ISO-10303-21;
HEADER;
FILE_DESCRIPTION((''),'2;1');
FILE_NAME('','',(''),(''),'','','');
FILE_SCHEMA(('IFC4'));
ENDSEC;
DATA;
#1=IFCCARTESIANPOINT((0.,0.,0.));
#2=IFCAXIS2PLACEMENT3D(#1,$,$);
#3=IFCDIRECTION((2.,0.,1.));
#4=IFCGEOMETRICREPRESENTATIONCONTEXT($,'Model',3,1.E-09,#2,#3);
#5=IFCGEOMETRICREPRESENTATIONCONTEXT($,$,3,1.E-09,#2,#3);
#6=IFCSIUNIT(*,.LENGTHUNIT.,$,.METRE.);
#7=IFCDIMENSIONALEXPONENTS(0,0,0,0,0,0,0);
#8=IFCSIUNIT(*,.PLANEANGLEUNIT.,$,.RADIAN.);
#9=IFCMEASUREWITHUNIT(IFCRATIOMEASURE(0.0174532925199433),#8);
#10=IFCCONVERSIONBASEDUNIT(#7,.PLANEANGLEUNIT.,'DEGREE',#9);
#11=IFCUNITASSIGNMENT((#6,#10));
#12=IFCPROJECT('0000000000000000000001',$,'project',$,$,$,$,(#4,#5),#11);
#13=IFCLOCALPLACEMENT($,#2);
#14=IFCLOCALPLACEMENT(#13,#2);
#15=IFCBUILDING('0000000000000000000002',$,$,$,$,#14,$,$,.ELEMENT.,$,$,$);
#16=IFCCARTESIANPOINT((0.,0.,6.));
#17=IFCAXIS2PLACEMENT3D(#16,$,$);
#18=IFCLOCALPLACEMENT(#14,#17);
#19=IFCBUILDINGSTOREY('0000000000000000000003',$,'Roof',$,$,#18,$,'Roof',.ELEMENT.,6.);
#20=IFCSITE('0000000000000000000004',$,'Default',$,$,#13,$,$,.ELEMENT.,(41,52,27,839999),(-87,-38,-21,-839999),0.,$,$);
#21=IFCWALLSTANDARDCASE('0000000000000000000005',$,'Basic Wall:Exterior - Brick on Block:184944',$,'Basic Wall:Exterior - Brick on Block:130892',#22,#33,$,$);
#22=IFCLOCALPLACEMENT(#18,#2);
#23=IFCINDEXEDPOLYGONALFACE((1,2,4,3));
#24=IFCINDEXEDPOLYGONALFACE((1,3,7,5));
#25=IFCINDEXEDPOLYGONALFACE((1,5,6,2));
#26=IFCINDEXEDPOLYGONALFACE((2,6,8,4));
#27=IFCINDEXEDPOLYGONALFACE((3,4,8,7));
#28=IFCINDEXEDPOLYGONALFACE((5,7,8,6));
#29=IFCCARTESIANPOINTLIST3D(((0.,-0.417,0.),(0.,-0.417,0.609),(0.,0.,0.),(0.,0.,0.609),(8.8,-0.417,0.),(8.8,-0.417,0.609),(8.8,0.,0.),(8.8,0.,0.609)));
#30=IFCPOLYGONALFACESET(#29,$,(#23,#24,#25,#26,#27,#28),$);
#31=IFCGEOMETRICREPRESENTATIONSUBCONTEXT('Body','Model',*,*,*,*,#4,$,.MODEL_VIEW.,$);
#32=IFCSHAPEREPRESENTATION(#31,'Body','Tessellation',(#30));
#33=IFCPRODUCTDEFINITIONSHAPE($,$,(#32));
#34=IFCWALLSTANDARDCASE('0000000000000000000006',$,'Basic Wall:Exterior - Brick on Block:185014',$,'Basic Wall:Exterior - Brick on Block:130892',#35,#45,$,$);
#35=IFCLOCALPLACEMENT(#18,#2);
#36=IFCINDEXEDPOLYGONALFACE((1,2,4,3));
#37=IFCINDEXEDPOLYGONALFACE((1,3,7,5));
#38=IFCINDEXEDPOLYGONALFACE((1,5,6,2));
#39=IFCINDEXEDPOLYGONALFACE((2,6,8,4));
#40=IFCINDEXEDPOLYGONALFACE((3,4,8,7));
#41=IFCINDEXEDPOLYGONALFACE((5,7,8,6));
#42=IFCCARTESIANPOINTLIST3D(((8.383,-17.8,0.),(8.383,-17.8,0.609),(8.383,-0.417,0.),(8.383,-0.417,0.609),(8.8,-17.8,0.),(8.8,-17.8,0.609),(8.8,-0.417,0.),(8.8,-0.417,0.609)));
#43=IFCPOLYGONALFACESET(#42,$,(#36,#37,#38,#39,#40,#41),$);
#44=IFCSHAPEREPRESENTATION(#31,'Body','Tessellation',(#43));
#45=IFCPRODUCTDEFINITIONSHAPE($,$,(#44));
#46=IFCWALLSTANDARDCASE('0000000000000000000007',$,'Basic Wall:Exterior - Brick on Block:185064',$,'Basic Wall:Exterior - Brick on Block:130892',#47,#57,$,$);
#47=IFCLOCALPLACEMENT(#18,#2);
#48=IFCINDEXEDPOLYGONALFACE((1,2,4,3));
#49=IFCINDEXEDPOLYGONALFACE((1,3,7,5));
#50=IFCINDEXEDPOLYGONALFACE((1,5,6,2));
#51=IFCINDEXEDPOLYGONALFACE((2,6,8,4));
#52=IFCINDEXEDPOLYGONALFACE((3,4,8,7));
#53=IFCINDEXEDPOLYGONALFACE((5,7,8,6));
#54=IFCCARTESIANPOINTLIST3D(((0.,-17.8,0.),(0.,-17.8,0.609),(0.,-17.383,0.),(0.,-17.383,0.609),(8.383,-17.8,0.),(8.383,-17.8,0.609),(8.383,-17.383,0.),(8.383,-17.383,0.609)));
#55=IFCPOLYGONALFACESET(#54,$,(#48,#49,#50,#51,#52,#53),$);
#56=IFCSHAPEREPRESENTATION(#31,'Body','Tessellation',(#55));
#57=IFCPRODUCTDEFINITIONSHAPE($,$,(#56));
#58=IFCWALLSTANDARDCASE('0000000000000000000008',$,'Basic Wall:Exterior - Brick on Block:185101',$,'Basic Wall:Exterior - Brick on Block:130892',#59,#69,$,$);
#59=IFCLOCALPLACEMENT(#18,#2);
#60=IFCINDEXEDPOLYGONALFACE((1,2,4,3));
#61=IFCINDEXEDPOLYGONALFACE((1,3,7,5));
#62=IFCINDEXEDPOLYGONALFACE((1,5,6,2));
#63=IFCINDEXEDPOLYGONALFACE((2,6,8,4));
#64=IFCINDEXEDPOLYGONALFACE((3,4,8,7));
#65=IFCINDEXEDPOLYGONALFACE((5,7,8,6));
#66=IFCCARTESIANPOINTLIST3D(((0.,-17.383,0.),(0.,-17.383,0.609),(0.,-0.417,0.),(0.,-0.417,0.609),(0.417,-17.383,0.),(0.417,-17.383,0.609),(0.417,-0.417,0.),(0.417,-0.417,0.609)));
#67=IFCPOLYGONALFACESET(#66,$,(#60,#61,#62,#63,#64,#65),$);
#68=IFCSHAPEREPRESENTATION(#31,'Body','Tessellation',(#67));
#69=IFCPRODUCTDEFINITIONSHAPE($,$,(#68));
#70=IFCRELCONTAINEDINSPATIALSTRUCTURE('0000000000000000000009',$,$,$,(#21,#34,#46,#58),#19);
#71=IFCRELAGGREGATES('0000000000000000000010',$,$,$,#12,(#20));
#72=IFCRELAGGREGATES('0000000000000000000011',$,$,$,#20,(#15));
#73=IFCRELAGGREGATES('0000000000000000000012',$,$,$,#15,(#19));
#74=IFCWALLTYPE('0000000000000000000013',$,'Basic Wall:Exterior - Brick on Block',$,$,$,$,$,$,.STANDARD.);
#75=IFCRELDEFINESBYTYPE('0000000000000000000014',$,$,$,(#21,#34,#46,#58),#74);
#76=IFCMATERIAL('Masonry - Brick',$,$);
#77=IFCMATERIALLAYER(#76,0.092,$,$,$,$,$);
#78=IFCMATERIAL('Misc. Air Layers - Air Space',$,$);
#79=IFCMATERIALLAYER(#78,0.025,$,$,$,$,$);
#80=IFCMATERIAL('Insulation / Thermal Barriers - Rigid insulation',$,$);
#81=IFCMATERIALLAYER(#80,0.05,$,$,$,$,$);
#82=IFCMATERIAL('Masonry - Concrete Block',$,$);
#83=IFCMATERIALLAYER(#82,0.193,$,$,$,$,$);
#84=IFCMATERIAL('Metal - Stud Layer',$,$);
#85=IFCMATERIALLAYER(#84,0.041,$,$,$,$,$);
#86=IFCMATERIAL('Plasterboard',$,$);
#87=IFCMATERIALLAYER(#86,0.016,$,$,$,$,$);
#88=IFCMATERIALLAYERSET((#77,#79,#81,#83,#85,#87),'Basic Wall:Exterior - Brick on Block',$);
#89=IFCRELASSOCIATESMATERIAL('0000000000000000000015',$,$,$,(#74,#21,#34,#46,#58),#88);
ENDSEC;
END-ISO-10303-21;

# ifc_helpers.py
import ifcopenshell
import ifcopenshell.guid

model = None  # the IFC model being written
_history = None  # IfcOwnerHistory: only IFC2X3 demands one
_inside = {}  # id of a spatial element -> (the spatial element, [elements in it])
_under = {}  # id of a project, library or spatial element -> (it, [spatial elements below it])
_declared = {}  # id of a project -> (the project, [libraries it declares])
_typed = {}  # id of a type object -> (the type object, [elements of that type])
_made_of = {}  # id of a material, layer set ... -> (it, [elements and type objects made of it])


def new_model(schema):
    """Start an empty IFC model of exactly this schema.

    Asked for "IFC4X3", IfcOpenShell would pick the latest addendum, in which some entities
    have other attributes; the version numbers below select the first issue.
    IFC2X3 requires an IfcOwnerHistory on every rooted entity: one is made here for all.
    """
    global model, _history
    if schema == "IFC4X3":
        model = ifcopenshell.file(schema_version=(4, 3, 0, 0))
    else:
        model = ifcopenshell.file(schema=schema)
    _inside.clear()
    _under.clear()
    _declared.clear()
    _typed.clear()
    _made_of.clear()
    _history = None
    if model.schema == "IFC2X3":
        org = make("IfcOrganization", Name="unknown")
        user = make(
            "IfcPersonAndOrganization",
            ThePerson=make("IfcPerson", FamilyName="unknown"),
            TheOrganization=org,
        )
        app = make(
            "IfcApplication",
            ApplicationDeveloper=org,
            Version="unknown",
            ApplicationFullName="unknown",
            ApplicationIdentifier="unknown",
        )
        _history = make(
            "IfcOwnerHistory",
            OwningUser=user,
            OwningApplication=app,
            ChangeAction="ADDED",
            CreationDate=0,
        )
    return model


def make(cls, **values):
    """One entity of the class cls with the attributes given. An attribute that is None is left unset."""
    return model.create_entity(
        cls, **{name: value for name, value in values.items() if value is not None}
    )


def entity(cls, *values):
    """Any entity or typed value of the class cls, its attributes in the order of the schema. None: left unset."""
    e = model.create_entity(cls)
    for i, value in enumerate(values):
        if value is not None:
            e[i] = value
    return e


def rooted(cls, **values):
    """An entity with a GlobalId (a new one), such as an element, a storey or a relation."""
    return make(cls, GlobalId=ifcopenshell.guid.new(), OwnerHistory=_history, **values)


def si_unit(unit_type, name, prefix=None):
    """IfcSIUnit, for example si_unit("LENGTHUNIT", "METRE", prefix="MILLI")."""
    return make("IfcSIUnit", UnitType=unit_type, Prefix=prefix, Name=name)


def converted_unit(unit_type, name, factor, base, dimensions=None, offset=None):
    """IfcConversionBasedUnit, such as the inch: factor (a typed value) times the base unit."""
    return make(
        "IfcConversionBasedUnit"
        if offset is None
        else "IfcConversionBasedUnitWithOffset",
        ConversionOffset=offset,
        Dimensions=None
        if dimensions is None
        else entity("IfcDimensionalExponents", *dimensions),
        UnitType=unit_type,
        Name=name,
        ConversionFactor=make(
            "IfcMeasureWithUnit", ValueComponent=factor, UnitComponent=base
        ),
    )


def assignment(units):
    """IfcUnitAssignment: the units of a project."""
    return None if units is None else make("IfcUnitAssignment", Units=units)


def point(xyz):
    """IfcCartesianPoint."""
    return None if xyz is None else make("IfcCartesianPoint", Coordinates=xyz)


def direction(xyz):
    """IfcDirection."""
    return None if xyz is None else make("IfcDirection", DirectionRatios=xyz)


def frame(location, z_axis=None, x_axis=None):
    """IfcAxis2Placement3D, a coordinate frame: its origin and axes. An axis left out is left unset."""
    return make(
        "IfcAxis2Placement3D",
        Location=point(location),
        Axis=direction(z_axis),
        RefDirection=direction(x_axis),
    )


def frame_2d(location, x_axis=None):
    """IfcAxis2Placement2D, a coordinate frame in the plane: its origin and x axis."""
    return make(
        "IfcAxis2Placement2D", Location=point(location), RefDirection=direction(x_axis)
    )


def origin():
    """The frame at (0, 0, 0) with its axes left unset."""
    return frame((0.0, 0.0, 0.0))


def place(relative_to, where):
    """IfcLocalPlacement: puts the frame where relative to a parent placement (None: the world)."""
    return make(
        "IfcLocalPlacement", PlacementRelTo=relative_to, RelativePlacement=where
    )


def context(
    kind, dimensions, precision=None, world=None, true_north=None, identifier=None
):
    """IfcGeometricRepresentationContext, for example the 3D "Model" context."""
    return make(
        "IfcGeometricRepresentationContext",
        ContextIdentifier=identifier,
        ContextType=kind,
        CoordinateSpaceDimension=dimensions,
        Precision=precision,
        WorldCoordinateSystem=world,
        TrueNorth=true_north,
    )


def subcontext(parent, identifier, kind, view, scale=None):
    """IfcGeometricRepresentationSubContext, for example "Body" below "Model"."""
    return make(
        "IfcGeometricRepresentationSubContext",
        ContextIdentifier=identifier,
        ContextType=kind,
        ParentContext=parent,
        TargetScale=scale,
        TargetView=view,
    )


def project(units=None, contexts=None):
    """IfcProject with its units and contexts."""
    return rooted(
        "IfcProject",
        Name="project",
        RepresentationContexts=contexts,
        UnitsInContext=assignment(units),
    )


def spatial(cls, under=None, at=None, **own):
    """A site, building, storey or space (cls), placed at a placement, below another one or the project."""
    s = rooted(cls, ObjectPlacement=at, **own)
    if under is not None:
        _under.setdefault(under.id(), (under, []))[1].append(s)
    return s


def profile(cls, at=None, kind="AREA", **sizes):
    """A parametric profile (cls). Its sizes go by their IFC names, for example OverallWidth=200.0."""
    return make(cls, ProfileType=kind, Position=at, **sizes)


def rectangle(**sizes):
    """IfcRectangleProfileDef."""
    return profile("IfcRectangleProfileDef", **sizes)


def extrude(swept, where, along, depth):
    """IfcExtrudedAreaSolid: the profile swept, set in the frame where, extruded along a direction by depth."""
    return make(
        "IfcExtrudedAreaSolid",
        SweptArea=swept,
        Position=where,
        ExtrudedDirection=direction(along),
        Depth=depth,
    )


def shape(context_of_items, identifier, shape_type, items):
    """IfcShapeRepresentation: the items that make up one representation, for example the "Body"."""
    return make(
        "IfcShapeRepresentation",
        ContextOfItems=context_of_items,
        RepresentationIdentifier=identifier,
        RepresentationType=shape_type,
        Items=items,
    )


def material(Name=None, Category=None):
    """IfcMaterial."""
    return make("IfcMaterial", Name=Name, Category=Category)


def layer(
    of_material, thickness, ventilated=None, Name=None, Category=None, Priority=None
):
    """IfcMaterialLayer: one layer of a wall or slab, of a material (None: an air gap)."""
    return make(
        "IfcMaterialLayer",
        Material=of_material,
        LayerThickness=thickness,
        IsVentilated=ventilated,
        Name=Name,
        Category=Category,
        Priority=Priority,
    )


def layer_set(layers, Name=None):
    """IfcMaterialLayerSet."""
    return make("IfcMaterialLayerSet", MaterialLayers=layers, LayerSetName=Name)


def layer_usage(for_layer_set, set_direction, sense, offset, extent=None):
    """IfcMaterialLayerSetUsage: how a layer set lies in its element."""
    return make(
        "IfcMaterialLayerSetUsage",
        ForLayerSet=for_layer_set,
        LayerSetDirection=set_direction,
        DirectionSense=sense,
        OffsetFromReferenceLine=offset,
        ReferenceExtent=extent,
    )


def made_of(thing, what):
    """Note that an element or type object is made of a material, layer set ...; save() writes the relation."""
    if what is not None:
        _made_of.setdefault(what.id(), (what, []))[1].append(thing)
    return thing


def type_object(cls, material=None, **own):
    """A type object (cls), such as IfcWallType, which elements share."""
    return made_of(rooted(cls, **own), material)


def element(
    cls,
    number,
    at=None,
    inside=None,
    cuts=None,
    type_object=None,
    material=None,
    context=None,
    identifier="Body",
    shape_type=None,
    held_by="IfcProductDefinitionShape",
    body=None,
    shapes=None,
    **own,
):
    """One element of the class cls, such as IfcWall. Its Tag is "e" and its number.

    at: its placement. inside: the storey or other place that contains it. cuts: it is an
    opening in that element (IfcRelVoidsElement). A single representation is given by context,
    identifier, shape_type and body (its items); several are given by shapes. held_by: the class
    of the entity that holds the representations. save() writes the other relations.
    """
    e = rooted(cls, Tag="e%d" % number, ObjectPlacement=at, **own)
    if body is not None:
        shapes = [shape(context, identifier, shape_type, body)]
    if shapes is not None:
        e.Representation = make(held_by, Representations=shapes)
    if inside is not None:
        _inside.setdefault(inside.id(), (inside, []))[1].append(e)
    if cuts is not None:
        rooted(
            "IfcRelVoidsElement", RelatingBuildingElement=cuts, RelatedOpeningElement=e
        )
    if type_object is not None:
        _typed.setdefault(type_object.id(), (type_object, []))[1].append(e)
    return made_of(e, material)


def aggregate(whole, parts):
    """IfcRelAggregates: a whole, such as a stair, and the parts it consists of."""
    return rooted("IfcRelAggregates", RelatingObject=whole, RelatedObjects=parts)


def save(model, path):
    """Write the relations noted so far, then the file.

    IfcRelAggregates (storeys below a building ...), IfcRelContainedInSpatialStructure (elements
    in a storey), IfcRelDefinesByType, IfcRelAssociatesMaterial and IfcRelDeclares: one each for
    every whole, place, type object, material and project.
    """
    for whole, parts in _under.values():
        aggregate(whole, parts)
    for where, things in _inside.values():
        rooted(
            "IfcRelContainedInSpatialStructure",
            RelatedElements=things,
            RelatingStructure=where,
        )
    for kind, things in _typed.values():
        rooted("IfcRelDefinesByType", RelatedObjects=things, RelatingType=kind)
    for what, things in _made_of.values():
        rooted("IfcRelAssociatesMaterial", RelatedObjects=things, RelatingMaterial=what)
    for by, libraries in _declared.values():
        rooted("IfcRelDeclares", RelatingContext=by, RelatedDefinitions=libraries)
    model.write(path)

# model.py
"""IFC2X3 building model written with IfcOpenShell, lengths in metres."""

from ifc_helpers import new_model, entity, si_unit, converted_unit, direction, frame, frame_2d, origin, place, context, subcontext, project, spatial, rectangle, extrude, material, layer, layer_set, layer_usage, type_object, element, save


model = new_model("IFC2X3")

# Units and contexts
model_context = context("Model", 3, precision=1e-09, world=origin(), true_north=direction((2.0, 0.0, 1.0)))
context_of_model = context(None, 3, precision=1e-09, world=origin(), true_north=direction((2.0, 0.0, 1.0)))
body_context = subcontext(model_context, "Body", "Model", "MODEL_VIEW")
ifc_project = project(units=[si_unit("LENGTHUNIT", "METRE"), converted_unit("PLANEANGLEUNIT", "DEGREE", entity("IfcRatioMeasure", 0.0174532925199433), si_unit("PLANEANGLEUNIT", "RADIAN"), dimensions=[0, 0, 0, 0, 0, 0, 0])], contexts=[model_context, context_of_model])

# Site, building, storey
site_placement = place(None, origin())
site = spatial("IfcSite", under=ifc_project, at=site_placement, Name="Default", CompositionType="ELEMENT", RefLatitude=(41, 52, 27, 839999), RefLongitude=(-87, -38, -21, -839999), RefElevation=0.0)
building_placement = place(site_placement, origin())
building = spatial("IfcBuilding", under=site, at=building_placement, CompositionType="ELEMENT")
storey_placement = place(building_placement, frame((0.0, 0.0, 6.0)))
storey = spatial("IfcBuildingStorey", under=building, at=storey_placement, Name="Roof", LongName="Roof", CompositionType="ELEMENT", Elevation=6.0)

# Walls
ifc_material_1 = material(Name="Masonry - Brick")
ifc_layer_1 = layer(ifc_material_1, 0.092)
ifc_material_2 = material(Name="Misc. Air Layers - Air Space")
ifc_layer_2 = layer(ifc_material_2, 0.025)
ifc_material_3 = material(Name="Insulation / Thermal Barriers - Rigid insulation")
ifc_layer_3 = layer(ifc_material_3, 0.05)
ifc_material_4 = material(Name="Masonry - Concrete Block")
ifc_layer_4 = layer(ifc_material_4, 0.193)
ifc_material_5 = material(Name="Metal - Stud Layer")
ifc_layer_5 = layer(ifc_material_5, 0.041)
ifc_material_6 = material(Name="Plasterboard")
ifc_layer_6 = layer(ifc_material_6, 0.016)
ifc_layer_set = layer_set([ifc_layer_1, ifc_layer_2, ifc_layer_3, ifc_layer_4, ifc_layer_5, ifc_layer_6], Name="Basic Wall:Exterior - Brick on Block")
ifc_layer_usage_1 = layer_usage(ifc_layer_set, "AXIS2", "NEGATIVE", 0.2085)
wall_type = type_object("IfcWallType", Name="Basic Wall:Exterior - Brick on Block", PredefinedType="STANDARD", material=ifc_layer_set)
wall_1_placement = place(storey_placement, frame((0.0, -0.2085, 0.0)))
element("IfcWallStandardCase", 1, at=wall_1_placement, inside=storey, type_object=wall_type, material=ifc_layer_usage_1, Name="Basic Wall:Exterior - Brick on Block:184944", ObjectType="Basic Wall:Exterior - Brick on Block:130892", context=body_context, shape_type="SweptSolid", body=[
    extrude(rectangle(XDim=8.8, YDim=0.417, at=frame_2d((4.4, 0.0), x_axis=(-1.0, 0.0))), origin(), (0.0, 0.0, 1.0), 0.609),
])
ifc_layer_usage_2 = layer_usage(ifc_layer_set, "AXIS2", "NEGATIVE", 0.2085)
wall_2_placement = place(storey_placement, frame((8.5915, -0.417, 0.0), z_axis=(0.0, 0.0, 1.0), x_axis=(0.0, -1.0, 0.0)))
element("IfcWallStandardCase", 2, at=wall_2_placement, inside=storey, type_object=wall_type, material=ifc_layer_usage_2, Name="Basic Wall:Exterior - Brick on Block:185014", ObjectType="Basic Wall:Exterior - Brick on Block:130892", context=body_context, shape_type="SweptSolid", body=[
    extrude(rectangle(XDim=17.383, YDim=0.417, at=frame_2d((8.6915, 0.0), x_axis=(-1.0, 0.0))), origin(), (0.0, 0.0, 1.0), 0.609),
])
ifc_layer_usage_3 = layer_usage(ifc_layer_set, "AXIS2", "NEGATIVE", 0.2085)
wall_3_placement = place(storey_placement, frame((8.383, -17.5915, 0.0), z_axis=(0.0, 0.0, 1.0), x_axis=(-1.0, 0.0, 0.0)))
element("IfcWallStandardCase", 3, at=wall_3_placement, inside=storey, type_object=wall_type, material=ifc_layer_usage_3, Name="Basic Wall:Exterior - Brick on Block:185064", ObjectType="Basic Wall:Exterior - Brick on Block:130892", context=body_context, shape_type="SweptSolid", body=[
    extrude(rectangle(XDim=8.383, YDim=0.417, at=frame_2d((4.1915, 0.0), x_axis=(-1.0, 0.0))), origin(), (0.0, 0.0, 1.0), 0.609),
])
ifc_layer_usage_4 = layer_usage(ifc_layer_set, "AXIS2", "NEGATIVE", 0.2085)
wall_4_placement = place(storey_placement, frame((0.2085, -17.383, 0.0), z_axis=(0.0, 0.0, 1.0), x_axis=(0.0, 1.0, 0.0)))
element("IfcWallStandardCase", 4, at=wall_4_placement, inside=storey, type_object=wall_type, material=ifc_layer_usage_4, Name="Basic Wall:Exterior - Brick on Block:185101", ObjectType="Basic Wall:Exterior - Brick on Block:130892", context=body_context, shape_type="SweptSolid", body=[
    extrude(rectangle(XDim=16.966, YDim=0.417, at=frame_2d((8.483, 0.0), x_axis=(-1.0, 0.0))), origin(), (0.0, 0.0, 1.0), 0.609),
])

save(model, "model.ifc")
